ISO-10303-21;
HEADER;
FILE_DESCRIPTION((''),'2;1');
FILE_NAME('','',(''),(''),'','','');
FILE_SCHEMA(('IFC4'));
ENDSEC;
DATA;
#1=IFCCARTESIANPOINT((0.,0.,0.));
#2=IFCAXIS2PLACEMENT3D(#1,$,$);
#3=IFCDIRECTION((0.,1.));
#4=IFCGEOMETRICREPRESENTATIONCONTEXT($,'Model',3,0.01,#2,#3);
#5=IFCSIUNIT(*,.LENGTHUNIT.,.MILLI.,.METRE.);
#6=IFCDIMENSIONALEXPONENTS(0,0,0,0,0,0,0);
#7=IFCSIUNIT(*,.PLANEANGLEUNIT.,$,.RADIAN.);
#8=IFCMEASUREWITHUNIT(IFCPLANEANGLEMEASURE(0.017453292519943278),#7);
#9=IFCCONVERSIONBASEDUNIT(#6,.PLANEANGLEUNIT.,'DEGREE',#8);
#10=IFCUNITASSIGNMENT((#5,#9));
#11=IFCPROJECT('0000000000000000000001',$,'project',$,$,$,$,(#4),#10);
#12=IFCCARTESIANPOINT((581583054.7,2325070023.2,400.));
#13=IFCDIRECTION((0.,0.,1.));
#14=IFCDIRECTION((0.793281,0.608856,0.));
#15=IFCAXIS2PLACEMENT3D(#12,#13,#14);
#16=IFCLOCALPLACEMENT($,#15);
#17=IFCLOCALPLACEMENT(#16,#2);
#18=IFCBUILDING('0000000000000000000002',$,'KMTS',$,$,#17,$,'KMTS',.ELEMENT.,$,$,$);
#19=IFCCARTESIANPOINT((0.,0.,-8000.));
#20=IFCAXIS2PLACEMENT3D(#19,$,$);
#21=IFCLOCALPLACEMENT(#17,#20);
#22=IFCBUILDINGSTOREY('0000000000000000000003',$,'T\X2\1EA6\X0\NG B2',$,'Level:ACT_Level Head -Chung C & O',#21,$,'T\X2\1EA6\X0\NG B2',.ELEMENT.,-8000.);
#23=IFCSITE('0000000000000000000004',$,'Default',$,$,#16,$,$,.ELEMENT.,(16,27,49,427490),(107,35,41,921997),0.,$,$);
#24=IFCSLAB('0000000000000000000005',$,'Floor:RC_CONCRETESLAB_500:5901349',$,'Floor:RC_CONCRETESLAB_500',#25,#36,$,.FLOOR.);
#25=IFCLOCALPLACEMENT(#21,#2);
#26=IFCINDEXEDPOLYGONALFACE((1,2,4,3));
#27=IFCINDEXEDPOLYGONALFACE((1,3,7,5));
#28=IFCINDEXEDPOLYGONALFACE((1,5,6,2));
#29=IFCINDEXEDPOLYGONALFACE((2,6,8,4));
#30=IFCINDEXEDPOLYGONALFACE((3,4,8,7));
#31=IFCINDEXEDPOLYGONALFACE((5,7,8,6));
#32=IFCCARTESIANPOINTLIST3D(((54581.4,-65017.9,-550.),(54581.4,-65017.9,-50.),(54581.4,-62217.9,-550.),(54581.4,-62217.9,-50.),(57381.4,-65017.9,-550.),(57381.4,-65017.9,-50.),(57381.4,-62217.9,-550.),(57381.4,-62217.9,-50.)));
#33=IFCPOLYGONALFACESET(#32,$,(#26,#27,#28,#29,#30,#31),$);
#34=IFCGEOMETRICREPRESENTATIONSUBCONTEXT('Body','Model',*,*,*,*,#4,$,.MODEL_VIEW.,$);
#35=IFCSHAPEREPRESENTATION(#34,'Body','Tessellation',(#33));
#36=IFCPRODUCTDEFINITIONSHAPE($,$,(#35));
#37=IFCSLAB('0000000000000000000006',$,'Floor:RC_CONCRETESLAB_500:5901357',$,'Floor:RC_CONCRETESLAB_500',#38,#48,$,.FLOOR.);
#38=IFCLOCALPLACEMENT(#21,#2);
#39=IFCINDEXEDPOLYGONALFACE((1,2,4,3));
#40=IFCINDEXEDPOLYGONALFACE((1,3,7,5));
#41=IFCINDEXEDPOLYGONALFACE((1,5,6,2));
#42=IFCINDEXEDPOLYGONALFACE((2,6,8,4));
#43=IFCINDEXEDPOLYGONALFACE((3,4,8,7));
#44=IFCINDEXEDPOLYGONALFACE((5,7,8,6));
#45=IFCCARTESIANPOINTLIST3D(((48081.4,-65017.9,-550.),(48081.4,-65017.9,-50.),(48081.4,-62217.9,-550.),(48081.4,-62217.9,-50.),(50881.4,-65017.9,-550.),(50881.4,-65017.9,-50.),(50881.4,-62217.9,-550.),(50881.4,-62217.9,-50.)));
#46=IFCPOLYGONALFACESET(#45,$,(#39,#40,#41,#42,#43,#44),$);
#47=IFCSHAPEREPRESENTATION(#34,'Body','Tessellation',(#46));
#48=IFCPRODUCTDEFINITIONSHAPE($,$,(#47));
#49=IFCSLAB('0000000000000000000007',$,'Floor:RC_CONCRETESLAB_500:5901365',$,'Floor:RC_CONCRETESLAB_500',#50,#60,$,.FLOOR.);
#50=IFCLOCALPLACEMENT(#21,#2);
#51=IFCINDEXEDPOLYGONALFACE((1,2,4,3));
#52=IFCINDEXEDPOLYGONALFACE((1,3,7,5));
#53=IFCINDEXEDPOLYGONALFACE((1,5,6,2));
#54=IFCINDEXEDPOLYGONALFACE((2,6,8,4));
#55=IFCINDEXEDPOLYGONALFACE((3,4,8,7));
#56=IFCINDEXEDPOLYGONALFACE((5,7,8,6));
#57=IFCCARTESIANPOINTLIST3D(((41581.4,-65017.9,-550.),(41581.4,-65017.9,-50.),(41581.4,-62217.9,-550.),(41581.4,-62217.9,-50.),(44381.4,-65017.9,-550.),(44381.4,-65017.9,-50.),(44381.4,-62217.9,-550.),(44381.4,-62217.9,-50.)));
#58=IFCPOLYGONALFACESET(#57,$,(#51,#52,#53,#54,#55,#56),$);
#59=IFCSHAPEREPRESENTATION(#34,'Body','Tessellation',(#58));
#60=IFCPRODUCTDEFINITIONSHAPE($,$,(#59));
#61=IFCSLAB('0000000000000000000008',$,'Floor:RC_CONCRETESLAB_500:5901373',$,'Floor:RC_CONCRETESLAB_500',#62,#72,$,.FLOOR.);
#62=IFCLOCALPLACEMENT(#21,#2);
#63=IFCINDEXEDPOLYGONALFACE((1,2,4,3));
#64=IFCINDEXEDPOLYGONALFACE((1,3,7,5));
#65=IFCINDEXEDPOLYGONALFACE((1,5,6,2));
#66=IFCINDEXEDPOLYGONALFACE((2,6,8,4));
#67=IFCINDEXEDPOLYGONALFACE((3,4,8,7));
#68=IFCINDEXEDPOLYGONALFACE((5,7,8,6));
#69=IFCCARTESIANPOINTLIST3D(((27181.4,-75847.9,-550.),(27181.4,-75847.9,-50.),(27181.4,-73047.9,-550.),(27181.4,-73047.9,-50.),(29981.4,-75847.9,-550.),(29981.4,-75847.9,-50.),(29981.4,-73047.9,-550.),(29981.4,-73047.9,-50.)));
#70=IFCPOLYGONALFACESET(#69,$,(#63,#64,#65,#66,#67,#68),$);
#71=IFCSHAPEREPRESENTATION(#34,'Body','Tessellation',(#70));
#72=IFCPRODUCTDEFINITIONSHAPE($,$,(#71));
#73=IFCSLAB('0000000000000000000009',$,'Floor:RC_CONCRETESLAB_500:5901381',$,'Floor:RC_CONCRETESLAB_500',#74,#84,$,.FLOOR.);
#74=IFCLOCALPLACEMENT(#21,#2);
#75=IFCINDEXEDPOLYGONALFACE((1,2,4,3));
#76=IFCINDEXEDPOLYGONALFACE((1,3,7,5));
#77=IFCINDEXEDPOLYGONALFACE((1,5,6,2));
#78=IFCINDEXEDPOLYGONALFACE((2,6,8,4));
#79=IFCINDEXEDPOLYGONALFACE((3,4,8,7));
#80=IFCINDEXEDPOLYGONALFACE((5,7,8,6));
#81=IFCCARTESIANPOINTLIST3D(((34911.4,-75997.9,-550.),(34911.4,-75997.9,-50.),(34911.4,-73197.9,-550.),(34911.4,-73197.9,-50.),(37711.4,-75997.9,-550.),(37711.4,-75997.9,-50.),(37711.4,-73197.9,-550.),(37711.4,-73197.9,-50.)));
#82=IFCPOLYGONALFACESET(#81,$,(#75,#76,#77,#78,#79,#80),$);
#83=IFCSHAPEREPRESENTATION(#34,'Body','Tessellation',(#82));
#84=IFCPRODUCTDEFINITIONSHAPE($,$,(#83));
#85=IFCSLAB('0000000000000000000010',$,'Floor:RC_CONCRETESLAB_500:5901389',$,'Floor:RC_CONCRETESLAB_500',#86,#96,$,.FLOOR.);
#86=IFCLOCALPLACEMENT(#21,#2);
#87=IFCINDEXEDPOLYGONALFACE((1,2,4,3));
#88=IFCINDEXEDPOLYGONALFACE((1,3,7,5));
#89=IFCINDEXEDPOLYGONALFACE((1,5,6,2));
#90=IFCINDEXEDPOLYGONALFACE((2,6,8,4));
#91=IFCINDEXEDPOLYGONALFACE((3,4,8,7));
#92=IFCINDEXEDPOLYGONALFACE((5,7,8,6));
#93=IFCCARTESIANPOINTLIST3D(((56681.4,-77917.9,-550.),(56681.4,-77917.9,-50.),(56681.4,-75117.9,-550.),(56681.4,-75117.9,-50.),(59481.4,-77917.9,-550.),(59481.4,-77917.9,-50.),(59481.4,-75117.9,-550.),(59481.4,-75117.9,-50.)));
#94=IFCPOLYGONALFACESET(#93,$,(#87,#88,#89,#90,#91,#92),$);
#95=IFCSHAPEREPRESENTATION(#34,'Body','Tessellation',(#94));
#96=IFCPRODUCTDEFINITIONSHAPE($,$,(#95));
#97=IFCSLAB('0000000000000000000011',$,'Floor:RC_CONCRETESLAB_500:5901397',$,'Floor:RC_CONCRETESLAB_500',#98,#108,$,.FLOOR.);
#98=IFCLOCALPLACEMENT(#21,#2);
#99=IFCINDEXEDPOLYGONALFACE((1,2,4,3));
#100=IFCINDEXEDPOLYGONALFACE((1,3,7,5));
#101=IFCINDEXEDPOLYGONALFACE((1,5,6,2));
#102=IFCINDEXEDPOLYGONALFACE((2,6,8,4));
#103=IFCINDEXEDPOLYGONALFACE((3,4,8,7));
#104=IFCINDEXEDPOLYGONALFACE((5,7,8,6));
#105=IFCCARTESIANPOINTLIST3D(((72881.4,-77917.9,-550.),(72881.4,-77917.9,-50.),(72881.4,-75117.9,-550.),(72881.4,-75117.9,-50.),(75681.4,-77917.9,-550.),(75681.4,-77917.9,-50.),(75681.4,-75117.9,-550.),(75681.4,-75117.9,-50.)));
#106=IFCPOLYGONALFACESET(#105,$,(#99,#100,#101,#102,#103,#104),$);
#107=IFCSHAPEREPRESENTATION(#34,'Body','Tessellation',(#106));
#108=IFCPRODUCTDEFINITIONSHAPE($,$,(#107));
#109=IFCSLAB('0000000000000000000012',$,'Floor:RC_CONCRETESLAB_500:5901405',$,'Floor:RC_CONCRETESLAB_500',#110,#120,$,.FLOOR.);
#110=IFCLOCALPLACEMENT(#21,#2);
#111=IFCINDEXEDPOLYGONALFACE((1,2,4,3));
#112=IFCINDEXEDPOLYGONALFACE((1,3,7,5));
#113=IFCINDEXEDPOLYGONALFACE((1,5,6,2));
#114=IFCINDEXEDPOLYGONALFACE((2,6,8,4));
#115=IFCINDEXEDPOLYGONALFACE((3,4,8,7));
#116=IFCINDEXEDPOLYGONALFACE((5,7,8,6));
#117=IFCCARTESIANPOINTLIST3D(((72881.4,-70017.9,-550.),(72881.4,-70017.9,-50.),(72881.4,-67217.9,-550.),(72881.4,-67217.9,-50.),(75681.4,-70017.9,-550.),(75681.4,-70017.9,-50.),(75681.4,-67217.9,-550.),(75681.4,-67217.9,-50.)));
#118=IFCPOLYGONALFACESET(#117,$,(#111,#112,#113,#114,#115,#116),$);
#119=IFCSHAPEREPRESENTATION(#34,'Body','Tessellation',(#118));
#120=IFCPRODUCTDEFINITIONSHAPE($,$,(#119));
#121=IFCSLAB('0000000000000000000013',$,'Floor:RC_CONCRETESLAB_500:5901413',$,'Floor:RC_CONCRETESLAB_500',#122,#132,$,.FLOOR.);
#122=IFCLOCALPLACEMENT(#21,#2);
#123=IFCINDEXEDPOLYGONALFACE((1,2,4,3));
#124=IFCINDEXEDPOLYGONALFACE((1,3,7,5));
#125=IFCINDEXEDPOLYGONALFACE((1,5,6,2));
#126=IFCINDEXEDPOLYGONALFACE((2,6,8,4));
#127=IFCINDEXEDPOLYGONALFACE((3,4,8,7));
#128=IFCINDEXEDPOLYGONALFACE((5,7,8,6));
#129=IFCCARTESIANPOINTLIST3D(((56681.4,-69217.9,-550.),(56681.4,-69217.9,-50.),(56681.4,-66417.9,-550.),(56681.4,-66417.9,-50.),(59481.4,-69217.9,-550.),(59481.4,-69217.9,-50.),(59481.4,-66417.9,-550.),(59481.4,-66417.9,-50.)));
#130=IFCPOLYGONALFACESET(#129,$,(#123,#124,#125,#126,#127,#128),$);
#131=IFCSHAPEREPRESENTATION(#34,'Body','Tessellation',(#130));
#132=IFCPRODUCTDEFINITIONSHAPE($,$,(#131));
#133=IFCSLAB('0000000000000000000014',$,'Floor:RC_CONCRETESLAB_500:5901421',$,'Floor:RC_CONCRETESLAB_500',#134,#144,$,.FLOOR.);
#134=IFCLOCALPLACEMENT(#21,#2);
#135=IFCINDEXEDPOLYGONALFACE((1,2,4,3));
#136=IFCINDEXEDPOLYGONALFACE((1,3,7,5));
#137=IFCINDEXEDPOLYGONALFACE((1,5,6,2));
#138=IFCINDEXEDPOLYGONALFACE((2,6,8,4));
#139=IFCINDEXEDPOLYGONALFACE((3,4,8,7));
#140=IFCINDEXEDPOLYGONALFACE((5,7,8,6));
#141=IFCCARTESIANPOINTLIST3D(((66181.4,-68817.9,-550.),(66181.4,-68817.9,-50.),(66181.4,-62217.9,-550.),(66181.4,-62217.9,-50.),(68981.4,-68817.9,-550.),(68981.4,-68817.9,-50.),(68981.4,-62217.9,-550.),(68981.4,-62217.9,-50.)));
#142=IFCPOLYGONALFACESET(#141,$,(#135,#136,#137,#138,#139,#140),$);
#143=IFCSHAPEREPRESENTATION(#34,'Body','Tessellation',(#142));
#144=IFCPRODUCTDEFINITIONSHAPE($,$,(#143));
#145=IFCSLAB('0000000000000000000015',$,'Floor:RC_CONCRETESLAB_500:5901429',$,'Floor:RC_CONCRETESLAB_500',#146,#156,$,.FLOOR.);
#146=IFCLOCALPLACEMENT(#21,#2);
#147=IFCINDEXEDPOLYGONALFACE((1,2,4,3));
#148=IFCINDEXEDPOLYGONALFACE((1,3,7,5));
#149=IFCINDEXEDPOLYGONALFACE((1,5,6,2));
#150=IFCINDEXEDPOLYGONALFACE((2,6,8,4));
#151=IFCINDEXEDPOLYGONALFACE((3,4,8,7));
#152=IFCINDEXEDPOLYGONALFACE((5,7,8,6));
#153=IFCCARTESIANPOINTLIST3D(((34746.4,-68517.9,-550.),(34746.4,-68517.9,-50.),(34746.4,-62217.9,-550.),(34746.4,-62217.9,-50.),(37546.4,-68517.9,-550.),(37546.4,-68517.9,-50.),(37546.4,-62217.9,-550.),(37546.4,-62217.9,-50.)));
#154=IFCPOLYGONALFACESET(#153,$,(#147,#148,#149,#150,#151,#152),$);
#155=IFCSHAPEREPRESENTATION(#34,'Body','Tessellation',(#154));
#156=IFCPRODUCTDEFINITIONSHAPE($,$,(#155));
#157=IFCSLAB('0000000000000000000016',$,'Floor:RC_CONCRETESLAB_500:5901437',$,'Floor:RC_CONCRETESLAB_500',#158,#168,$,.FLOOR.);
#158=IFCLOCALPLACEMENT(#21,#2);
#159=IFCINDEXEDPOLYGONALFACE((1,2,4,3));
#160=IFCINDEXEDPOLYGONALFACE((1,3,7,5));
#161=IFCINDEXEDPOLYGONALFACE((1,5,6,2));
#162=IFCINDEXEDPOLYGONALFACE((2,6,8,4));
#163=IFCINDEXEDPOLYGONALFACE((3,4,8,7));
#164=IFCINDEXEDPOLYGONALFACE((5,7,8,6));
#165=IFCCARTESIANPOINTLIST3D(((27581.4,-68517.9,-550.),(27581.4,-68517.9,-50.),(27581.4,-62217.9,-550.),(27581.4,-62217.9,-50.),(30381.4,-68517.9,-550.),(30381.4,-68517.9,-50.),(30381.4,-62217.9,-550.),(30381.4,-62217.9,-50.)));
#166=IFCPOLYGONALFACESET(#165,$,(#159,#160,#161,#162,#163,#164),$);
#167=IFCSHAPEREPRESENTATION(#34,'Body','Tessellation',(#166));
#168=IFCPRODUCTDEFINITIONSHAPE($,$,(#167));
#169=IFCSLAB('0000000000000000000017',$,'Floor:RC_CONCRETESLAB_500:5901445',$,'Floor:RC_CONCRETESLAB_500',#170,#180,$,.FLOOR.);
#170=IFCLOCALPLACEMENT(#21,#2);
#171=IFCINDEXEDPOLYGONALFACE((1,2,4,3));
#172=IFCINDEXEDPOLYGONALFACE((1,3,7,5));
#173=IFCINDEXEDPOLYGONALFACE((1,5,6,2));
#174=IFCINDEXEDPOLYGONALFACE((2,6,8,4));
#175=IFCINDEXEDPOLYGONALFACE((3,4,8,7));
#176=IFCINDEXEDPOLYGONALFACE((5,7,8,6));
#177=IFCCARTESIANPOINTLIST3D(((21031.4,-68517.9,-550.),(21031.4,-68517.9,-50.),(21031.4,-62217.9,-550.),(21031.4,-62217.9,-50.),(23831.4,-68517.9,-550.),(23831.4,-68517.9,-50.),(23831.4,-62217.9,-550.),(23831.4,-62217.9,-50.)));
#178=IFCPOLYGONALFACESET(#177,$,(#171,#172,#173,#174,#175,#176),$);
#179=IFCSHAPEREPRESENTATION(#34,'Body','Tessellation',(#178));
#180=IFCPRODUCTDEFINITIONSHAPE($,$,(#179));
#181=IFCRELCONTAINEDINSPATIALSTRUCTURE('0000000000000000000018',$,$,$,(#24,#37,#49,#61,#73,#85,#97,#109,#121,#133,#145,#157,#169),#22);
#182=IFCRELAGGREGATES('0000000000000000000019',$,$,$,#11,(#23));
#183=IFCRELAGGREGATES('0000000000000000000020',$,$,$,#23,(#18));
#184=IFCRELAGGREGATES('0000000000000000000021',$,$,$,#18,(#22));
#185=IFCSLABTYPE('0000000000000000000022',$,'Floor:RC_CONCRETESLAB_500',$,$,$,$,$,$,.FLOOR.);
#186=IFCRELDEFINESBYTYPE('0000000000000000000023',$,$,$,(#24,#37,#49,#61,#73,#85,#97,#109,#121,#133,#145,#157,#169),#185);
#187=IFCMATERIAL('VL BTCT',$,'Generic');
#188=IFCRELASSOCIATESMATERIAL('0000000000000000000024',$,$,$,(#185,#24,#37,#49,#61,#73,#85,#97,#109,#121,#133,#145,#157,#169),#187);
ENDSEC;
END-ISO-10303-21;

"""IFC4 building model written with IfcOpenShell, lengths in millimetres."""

from ifc_helpers import new_model, entity, si_unit, converted_unit, direction, frame, origin, place, context, subcontext, project, spatial, indexed_curve, outline, extrude, material, type_object, element, save


model = new_model("IFC4")

# Units and contexts
model_context = context("Model", 3, precision=0.01, world=origin(), true_north=direction((0.0, 1.0)))
body_context = subcontext(model_context, "Body", "Model", "MODEL_VIEW")
ifc_project = project(units=[si_unit("LENGTHUNIT", "METRE", prefix="MILLI"), converted_unit("PLANEANGLEUNIT", "DEGREE", entity("IfcPlaneAngleMeasure", 0.017453292519943278), si_unit("PLANEANGLEUNIT", "RADIAN"), dimensions=[0, 0, 0, 0, 0, 0, 0])], contexts=[model_context])

# Site, building, storey
site_placement = place(None, frame((581583054.7, 2325070023.2, 400.0), z_axis=(0.0, 0.0, 1.0), x_axis=(0.793281, 0.608856, 0.0)))
site = spatial("IfcSite", under=ifc_project, at=site_placement, Name="Default", CompositionType="ELEMENT", RefLatitude=(16, 27, 49, 427490), RefLongitude=(107, 35, 41, 921997), RefElevation=0.0)
building_placement = place(site_placement, origin())
building = spatial("IfcBuilding", under=site, at=building_placement, Name="KMTS", LongName="KMTS", CompositionType="ELEMENT")
storey_placement = place(building_placement, frame((0.0, 0.0, -8000.0)))
storey = spatial("IfcBuildingStorey", under=building, at=storey_placement, Name="TẦNG B2", ObjectType="Level:ACT_Level Head -Chung C & O", LongName="TẦNG B2", CompositionType="ELEMENT", Elevation=-8000.0)

# Slabs
ifc_material = material(Name="VL BTCT", Category="Generic")
slab_type = type_object("IfcSlabType", Name="Floor:RC_CONCRETESLAB_500", PredefinedType="FLOOR", material=ifc_material)
slab_1_placement = place(storey_placement, origin())
element("IfcSlab", 1, at=slab_1_placement, inside=storey, type_object=slab_type, material=ifc_material, Name="Floor:RC_CONCRETESLAB_500:5901349", ObjectType="Floor:RC_CONCRETESLAB_500", PredefinedType="FLOOR", context=body_context, shape_type="SweptSolid", body=[
    extrude(outline(indexed_curve([(-1400.0, -1400.0), (1400.0, -1400.0), (1400.0, 1400.0), (-1400.0, 1400.0), (-1400.0, -1400.0)], self_intersect=False)), frame((55981.4, -63617.9, -50.0), z_axis=(0.0, 0.0, -1.0), x_axis=(0.0, 1.0, 0.0)), (0.0, 0.0, 1.0), 500.0),
])
slab_2_placement = place(storey_placement, origin())
element("IfcSlab", 2, at=slab_2_placement, inside=storey, type_object=slab_type, material=ifc_material, Name="Floor:RC_CONCRETESLAB_500:5901357", ObjectType="Floor:RC_CONCRETESLAB_500", PredefinedType="FLOOR", context=body_context, shape_type="SweptSolid", body=[
    extrude(outline(indexed_curve([(-1400.0, -1400.0), (1400.0, -1400.0), (1400.0, 1400.0), (-1400.0, 1400.0), (-1400.0, -1400.0)], self_intersect=False)), frame((49481.4, -63617.9, -50.0), z_axis=(0.0, 0.0, -1.0), x_axis=(0.0, 1.0, 0.0)), (0.0, 0.0, 1.0), 500.0),
])
slab_3_placement = place(storey_placement, origin())
element("IfcSlab", 3, at=slab_3_placement, inside=storey, type_object=slab_type, material=ifc_material, Name="Floor:RC_CONCRETESLAB_500:5901365", ObjectType="Floor:RC_CONCRETESLAB_500", PredefinedType="FLOOR", context=body_context, shape_type="SweptSolid", body=[
    extrude(outline(indexed_curve([(-1400.0, -1400.0), (1400.0, -1400.0), (1400.0, 1400.0), (-1400.0, 1400.0), (-1400.0, -1400.0)], self_intersect=False)), frame((42981.4, -63617.9, -50.0), z_axis=(0.0, 0.0, -1.0), x_axis=(0.0, 1.0, 0.0)), (0.0, 0.0, 1.0), 500.0),
])
slab_4_placement = place(storey_placement, origin())
element("IfcSlab", 4, at=slab_4_placement, inside=storey, type_object=slab_type, material=ifc_material, Name="Floor:RC_CONCRETESLAB_500:5901373", ObjectType="Floor:RC_CONCRETESLAB_500", PredefinedType="FLOOR", context=body_context, shape_type="SweptSolid", body=[
    extrude(outline(indexed_curve([(-1400.0, -1400.0), (1400.0, -1400.0), (1400.0, 1400.0), (-1400.0, 1400.0), (-1400.0, -1400.0)], self_intersect=False)), frame((28581.4, -74447.9, -50.0), z_axis=(0.0, 0.0, -1.0), x_axis=(0.0, 1.0, 0.0)), (0.0, 0.0, 1.0), 500.0),
])
slab_5_placement = place(storey_placement, origin())
element("IfcSlab", 5, at=slab_5_placement, inside=storey, type_object=slab_type, material=ifc_material, Name="Floor:RC_CONCRETESLAB_500:5901381", ObjectType="Floor:RC_CONCRETESLAB_500", PredefinedType="FLOOR", context=body_context, shape_type="SweptSolid", body=[
    extrude(outline(indexed_curve([(-1400.0, -1400.0), (1400.0, -1400.0), (1400.0, 1400.0), (-1400.0, 1400.0), (-1400.0, -1400.0)], self_intersect=False)), frame((36311.4, -74597.9, -50.0), z_axis=(0.0, 0.0, -1.0), x_axis=(0.0, 1.0, 0.0)), (0.0, 0.0, 1.0), 500.0),
])
slab_6_placement = place(storey_placement, origin())
element("IfcSlab", 6, at=slab_6_placement, inside=storey, type_object=slab_type, material=ifc_material, Name="Floor:RC_CONCRETESLAB_500:5901389", ObjectType="Floor:RC_CONCRETESLAB_500", PredefinedType="FLOOR", context=body_context, shape_type="SweptSolid", body=[
    extrude(outline(indexed_curve([(-1400.0, -1400.0), (1400.0, -1400.0), (1400.0, 1400.0), (-1400.0, 1400.0), (-1400.0, -1400.0)], self_intersect=False)), frame((58081.4, -76517.9, -50.0), z_axis=(0.0, 0.0, -1.0), x_axis=(0.0, 1.0, 0.0)), (0.0, 0.0, 1.0), 500.0),
])
slab_7_placement = place(storey_placement, origin())
element("IfcSlab", 7, at=slab_7_placement, inside=storey, type_object=slab_type, material=ifc_material, Name="Floor:RC_CONCRETESLAB_500:5901397", ObjectType="Floor:RC_CONCRETESLAB_500", PredefinedType="FLOOR", context=body_context, shape_type="SweptSolid", body=[
    extrude(outline(indexed_curve([(-1400.0, -1400.0), (1400.0, -1400.0), (1400.0, 1400.0), (-1400.0, 1400.0), (-1400.0, -1400.0)], self_intersect=False)), frame((74281.4, -76517.9, -50.0), z_axis=(0.0, 0.0, -1.0), x_axis=(0.0, 1.0, 0.0)), (0.0, 0.0, 1.0), 500.0),
])
slab_8_placement = place(storey_placement, origin())
element("IfcSlab", 8, at=slab_8_placement, inside=storey, type_object=slab_type, material=ifc_material, Name="Floor:RC_CONCRETESLAB_500:5901405", ObjectType="Floor:RC_CONCRETESLAB_500", PredefinedType="FLOOR", context=body_context, shape_type="SweptSolid", body=[
    extrude(outline(indexed_curve([(-1400.0, -1400.0), (1400.0, -1400.0), (1400.0, 1400.0), (-1400.0, 1400.0), (-1400.0, -1400.0)], self_intersect=False)), frame((74281.4, -68617.9, -50.0), z_axis=(0.0, 0.0, -1.0), x_axis=(0.0, 1.0, 0.0)), (0.0, 0.0, 1.0), 500.0),
])
slab_9_placement = place(storey_placement, origin())
element("IfcSlab", 9, at=slab_9_placement, inside=storey, type_object=slab_type, material=ifc_material, Name="Floor:RC_CONCRETESLAB_500:5901413", ObjectType="Floor:RC_CONCRETESLAB_500", PredefinedType="FLOOR", context=body_context, shape_type="SweptSolid", body=[
    extrude(outline(indexed_curve([(-1400.0, -1400.0), (1400.0, -1400.0), (1400.0, 1400.0), (-1400.0, 1400.0), (-1400.0, -1400.0)], self_intersect=False)), frame((58081.4, -67817.9, -50.0), z_axis=(0.0, 0.0, -1.0), x_axis=(0.0, 1.0, 0.0)), (0.0, 0.0, 1.0), 500.0),
])
slab_10_placement = place(storey_placement, origin())
element("IfcSlab", 10, at=slab_10_placement, inside=storey, type_object=slab_type, material=ifc_material, Name="Floor:RC_CONCRETESLAB_500:5901421", ObjectType="Floor:RC_CONCRETESLAB_500", PredefinedType="FLOOR", context=body_context, shape_type="SweptSolid", body=[
    extrude(outline(indexed_curve([(-3300.0, -1400.0), (3300.0, -1400.0), (3300.0, 1400.0), (-3300.0, 1400.0), (-3300.0, -1400.0)], self_intersect=False)), frame((67581.4, -65517.9, -50.0), z_axis=(0.0, 0.0, -1.0), x_axis=(0.0, 1.0, 0.0)), (0.0, 0.0, 1.0), 500.0),
])
slab_11_placement = place(storey_placement, origin())
element("IfcSlab", 11, at=slab_11_placement, inside=storey, type_object=slab_type, material=ifc_material, Name="Floor:RC_CONCRETESLAB_500:5901429", ObjectType="Floor:RC_CONCRETESLAB_500", PredefinedType="FLOOR", context=body_context, shape_type="SweptSolid", body=[
    extrude(outline(indexed_curve([(-3150.0, -1400.0), (3150.0, -1400.0), (3150.0, 1400.0), (-3150.0, 1400.0), (-3150.0, -1400.0)], self_intersect=False)), frame((36146.4, -65367.9, -50.0), z_axis=(0.0, 0.0, -1.0), x_axis=(0.0, 1.0, 0.0)), (0.0, 0.0, 1.0), 500.0),
])
slab_12_placement = place(storey_placement, origin())
element("IfcSlab", 12, at=slab_12_placement, inside=storey, type_object=slab_type, material=ifc_material, Name="Floor:RC_CONCRETESLAB_500:5901437", ObjectType="Floor:RC_CONCRETESLAB_500", PredefinedType="FLOOR", context=body_context, shape_type="SweptSolid", body=[
    extrude(outline(indexed_curve([(-3150.0, -1400.0), (3150.0, -1400.0), (3150.0, 1400.0), (-3150.0, 1400.0), (-3150.0, -1400.0)], self_intersect=False)), frame((28981.4, -65367.9, -50.0), z_axis=(0.0, 0.0, -1.0), x_axis=(0.0, 1.0, 0.0)), (0.0, 0.0, 1.0), 500.0),
])
slab_13_placement = place(storey_placement, origin())
element("IfcSlab", 13, at=slab_13_placement, inside=storey, type_object=slab_type, material=ifc_material, Name="Floor:RC_CONCRETESLAB_500:5901445", ObjectType="Floor:RC_CONCRETESLAB_500", PredefinedType="FLOOR", context=body_context, shape_type="SweptSolid", body=[
    extrude(outline(indexed_curve([(-3150.0, -1400.0), (3150.0, -1400.0), (3150.0, 1400.0), (-3150.0, 1400.0), (-3150.0, -1400.0)], self_intersect=False)), frame((22431.4, -65367.9, -50.0), z_axis=(0.0, 0.0, -1.0), x_axis=(0.0, 1.0, 0.0)), (0.0, 0.0, 1.0), 500.0),
])

save(model, "model.ifc")
